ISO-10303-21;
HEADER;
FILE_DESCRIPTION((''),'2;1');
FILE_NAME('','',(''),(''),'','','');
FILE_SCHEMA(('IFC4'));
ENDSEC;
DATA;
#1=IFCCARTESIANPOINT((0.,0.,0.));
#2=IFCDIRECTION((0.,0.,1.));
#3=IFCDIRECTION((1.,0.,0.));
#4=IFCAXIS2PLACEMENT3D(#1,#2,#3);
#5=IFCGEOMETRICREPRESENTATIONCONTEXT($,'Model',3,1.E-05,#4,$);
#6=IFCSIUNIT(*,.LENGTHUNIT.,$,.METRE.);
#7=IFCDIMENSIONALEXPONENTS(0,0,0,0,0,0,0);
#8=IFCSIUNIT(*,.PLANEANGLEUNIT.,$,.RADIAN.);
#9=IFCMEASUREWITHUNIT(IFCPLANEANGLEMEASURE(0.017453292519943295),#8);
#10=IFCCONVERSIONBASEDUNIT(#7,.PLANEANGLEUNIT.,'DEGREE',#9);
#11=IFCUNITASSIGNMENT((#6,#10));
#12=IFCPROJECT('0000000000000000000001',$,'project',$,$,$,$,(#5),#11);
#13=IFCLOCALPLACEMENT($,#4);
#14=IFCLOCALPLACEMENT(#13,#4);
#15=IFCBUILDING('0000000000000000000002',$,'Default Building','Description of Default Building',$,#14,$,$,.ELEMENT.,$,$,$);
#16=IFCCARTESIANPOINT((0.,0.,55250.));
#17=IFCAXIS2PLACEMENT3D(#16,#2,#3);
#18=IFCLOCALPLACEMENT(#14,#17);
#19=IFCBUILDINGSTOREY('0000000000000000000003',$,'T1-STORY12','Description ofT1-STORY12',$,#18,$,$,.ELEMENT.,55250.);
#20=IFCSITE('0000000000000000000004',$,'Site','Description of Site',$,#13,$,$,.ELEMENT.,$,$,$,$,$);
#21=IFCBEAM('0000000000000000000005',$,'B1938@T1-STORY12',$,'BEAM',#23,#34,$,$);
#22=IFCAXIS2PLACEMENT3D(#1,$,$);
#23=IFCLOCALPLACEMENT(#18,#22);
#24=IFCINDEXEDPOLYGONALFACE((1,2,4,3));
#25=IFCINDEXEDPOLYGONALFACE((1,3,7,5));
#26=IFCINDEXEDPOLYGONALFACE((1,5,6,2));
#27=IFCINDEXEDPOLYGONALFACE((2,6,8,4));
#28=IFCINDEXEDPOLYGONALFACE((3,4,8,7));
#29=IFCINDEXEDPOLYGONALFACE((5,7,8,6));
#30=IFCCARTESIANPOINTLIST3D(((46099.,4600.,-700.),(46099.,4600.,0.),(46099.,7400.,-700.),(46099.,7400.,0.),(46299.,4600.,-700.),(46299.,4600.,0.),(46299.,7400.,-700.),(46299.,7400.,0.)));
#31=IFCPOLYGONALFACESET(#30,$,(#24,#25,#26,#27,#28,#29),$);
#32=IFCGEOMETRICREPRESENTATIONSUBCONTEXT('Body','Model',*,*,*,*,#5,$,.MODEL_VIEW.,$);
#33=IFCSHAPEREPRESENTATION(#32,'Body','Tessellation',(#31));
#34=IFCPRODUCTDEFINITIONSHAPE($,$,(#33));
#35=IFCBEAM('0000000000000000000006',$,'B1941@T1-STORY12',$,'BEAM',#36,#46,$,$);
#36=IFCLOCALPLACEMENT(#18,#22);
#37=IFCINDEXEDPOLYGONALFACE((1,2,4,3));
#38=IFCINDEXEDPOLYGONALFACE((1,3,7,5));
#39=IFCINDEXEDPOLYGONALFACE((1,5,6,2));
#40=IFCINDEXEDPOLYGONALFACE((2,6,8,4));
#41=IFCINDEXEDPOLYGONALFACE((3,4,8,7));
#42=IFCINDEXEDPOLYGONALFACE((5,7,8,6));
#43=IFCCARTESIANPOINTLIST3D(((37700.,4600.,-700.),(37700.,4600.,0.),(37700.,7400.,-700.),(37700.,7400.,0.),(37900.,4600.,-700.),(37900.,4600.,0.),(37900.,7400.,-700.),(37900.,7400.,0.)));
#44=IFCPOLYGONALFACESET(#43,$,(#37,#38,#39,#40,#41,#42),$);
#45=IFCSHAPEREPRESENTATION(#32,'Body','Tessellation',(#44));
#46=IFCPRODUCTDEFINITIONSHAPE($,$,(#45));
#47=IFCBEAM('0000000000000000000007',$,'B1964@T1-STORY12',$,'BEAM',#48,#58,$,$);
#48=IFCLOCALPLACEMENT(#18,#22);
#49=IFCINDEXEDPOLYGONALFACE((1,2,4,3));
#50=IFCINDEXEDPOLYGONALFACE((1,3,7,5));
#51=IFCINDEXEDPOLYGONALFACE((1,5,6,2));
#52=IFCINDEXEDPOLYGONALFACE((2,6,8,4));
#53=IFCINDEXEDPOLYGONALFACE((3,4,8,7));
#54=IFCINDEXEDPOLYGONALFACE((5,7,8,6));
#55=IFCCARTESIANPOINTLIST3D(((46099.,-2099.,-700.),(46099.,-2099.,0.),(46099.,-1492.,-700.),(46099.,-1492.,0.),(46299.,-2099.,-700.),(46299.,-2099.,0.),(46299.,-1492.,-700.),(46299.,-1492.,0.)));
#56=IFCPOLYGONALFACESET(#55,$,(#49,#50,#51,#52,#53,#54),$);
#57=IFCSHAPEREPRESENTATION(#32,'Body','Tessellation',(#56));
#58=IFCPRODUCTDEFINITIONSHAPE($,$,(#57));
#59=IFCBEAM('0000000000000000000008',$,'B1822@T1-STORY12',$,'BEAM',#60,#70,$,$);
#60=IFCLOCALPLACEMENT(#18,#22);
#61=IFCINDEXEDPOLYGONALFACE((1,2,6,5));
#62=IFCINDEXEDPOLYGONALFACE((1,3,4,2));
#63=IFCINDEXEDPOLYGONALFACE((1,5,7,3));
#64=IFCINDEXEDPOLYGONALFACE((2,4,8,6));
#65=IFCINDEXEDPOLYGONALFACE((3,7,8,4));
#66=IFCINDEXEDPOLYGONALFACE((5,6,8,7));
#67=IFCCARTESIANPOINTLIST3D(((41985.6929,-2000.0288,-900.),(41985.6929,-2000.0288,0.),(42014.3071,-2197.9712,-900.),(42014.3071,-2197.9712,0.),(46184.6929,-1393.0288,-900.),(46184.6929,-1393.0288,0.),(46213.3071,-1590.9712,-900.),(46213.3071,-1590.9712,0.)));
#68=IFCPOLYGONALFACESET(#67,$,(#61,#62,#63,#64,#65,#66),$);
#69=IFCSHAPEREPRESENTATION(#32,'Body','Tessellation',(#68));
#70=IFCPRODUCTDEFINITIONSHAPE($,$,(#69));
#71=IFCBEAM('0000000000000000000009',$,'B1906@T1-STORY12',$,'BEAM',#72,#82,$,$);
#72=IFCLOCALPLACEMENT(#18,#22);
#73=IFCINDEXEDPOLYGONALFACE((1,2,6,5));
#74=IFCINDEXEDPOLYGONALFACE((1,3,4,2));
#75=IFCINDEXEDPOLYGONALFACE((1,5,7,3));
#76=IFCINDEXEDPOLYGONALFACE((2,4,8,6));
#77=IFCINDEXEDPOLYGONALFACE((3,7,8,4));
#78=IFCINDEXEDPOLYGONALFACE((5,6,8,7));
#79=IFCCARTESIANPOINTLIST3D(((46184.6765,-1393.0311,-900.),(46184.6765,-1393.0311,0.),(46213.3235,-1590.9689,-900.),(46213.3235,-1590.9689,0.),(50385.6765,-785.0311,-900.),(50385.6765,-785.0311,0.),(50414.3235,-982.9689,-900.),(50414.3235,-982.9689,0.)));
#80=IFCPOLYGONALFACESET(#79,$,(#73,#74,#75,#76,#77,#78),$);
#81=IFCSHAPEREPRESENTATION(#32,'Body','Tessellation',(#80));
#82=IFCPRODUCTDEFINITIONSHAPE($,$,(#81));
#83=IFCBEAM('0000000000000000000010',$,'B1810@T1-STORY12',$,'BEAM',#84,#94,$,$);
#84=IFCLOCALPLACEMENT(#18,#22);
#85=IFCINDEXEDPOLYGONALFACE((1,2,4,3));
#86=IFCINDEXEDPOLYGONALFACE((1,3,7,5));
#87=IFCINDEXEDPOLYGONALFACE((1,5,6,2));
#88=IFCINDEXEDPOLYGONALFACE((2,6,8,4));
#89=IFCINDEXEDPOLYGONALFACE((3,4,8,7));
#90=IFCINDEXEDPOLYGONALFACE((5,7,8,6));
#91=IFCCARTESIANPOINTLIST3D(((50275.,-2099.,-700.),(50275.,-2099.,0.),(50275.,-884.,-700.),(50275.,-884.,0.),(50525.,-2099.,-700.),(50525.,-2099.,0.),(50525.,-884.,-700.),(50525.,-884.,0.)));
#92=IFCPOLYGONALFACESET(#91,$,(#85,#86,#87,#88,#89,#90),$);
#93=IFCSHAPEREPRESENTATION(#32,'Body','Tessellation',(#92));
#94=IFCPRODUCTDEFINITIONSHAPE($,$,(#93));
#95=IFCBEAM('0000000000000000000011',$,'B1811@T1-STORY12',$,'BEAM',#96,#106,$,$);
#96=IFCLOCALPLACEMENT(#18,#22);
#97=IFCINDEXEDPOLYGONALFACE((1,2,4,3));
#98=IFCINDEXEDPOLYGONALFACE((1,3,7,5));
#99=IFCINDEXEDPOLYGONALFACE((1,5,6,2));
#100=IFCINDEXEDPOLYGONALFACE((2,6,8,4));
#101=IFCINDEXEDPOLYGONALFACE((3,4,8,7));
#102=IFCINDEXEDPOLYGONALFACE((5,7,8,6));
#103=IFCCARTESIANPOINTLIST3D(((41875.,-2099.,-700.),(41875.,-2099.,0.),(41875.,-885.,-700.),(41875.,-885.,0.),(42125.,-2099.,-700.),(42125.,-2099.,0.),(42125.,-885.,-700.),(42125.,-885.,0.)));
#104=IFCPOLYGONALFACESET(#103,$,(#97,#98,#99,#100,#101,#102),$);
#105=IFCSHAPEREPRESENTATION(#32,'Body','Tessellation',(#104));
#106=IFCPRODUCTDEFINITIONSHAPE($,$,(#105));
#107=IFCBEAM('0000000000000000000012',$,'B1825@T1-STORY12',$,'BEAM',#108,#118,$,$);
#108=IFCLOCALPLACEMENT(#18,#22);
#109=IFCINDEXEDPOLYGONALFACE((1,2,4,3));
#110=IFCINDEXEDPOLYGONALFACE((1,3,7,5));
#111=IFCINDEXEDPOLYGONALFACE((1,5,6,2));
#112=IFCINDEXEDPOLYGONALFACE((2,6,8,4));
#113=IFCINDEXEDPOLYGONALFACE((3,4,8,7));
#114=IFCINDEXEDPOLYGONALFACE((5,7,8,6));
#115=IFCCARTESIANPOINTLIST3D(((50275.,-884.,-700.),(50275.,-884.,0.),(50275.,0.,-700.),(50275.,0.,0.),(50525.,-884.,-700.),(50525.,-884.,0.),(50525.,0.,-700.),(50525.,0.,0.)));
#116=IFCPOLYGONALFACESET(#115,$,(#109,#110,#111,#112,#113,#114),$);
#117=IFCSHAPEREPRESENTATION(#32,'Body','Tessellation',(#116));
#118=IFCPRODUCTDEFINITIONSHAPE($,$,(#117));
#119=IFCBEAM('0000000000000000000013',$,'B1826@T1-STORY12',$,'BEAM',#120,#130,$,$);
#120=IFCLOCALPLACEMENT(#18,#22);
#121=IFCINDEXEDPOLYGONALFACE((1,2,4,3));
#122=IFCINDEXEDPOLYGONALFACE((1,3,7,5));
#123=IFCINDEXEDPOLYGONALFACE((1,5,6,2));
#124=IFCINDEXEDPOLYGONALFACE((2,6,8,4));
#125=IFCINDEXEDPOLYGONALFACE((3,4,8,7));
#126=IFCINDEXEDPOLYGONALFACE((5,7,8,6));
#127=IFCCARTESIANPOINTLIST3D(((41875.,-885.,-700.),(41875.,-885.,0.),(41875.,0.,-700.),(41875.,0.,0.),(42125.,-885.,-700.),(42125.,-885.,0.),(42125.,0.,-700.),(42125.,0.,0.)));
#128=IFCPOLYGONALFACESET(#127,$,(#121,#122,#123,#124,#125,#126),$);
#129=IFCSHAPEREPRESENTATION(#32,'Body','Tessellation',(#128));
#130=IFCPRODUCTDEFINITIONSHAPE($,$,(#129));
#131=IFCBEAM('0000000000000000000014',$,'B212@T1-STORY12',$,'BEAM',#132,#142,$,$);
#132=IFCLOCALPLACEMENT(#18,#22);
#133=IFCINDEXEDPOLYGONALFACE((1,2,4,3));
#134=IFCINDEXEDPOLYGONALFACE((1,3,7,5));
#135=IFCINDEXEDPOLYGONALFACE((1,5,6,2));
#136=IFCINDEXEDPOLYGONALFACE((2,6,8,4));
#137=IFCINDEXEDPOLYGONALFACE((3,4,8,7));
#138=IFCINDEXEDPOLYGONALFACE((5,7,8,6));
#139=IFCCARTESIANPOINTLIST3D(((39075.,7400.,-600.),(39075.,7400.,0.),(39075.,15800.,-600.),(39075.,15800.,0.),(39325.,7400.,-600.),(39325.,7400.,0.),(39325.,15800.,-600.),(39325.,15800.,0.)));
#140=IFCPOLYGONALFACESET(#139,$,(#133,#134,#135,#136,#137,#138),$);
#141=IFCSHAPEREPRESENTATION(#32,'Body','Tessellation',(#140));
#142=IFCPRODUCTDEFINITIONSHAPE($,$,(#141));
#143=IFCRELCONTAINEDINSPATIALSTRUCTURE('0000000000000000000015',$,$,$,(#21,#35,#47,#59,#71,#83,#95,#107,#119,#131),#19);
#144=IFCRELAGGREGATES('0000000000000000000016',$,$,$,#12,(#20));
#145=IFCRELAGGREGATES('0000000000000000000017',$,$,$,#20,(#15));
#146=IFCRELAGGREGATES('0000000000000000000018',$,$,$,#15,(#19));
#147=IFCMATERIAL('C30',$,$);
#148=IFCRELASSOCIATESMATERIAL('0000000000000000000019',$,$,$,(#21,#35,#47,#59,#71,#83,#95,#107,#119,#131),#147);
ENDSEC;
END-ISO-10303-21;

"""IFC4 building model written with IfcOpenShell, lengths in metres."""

from ifc_helpers import new_model, entity, si_unit, converted_unit, frame, origin_with_axes, place, context, subcontext, project, spatial, rectangle, extrude, material, element, save


model = new_model("IFC4")

# Units and contexts
model_context = context("Model", 3, precision=1e-05, world=origin_with_axes())
body_context = subcontext(model_context, "Body", "Model", "MODEL_VIEW")
ifc_project = project(units=[si_unit("LENGTHUNIT", "METRE"), converted_unit("PLANEANGLEUNIT", "DEGREE", entity("IfcPlaneAngleMeasure", 0.017453292519943295), si_unit("PLANEANGLEUNIT", "RADIAN"), dimensions=[0, 0, 0, 0, 0, 0, 0])], contexts=[model_context])

# Site, building, storey
site_placement = place(None, origin_with_axes())
site = spatial("IfcSite", under=ifc_project, at=site_placement, Name="Site", Description="Description of Site", CompositionType="ELEMENT")
building_placement = place(site_placement, origin_with_axes())
building = spatial("IfcBuilding", under=site, at=building_placement, Name="Default Building", Description="Description of Default Building", CompositionType="ELEMENT")
storey_placement = place(building_placement, frame((0.0, 0.0, 55250.0), z_axis=(0.0, 0.0, 1.0), x_axis=(1.0, 0.0, 0.0)))
storey = spatial("IfcBuildingStorey", under=building, at=storey_placement, Name="T1-STORY12", Description="Description ofT1-STORY12", CompositionType="ELEMENT", Elevation=55250.0)

# Beams
ifc_material_1 = material(Name="C30")
for number, where, z_axis, x_axis, name in (
    (1, (46199.0, 4600.0, -350.0), (0.0, 1.0, 0.0), (-1.0, 0.0, 0.0), "B1938@T1-STORY12"),
    (2, (37800.0, 4600.0, -350.0), (0.0, 1.0, 0.0), (-1.0, 0.0, 0.0), "B1941@T1-STORY12"),
):
    element("IfcBeam", number, at=place(storey_placement, frame(where, z_axis=z_axis, x_axis=x_axis)), inside=storey, material=ifc_material_1, Name=name, ObjectType="BEAM", context=body_context, shape_type="SweptSolid", body=[
        extrude(rectangle(XDim=200.0, YDim=700.0), origin_with_axes(), (0.0, 0.0, 1.0), 2800.0),
    ])
beam_1_placement = place(storey_placement, frame((46199.0, -2099.0, -350.0), z_axis=(0.0, 1.0, 0.0), x_axis=(-1.0, 0.0, 0.0)))
element("IfcBeam", 3, at=beam_1_placement, inside=storey, material=ifc_material_1, Name="B1964@T1-STORY12", ObjectType="BEAM", context=body_context, shape_type="SweptSolid", body=[
    extrude(rectangle(XDim=200.0, YDim=700.0), origin_with_axes(), (0.0, 0.0, 1.0), 607.0),
])
beam_2_placement = place(storey_placement, frame((42000.0, -2099.0, -450.0), z_axis=(0.989712, 0.143071, 0.0), x_axis=(-0.143071, 0.989712, 0.0)))
element("IfcBeam", 4, at=beam_2_placement, inside=storey, material=ifc_material_1, Name="B1822@T1-STORY12", ObjectType="BEAM", context=body_context, shape_type="SweptSolid", body=[
    extrude(rectangle(XDim=200.0, YDim=900.0), origin_with_axes(), (0.0, 0.0, 1.0), 4242.6466),
])
beam_3_placement = place(storey_placement, frame((46199.0, -1492.0, -450.0), z_axis=(0.989689, 0.143235, 0.0), x_axis=(-0.143235, 0.989689, 0.0)))
element("IfcBeam", 5, at=beam_3_placement, inside=storey, material=ifc_material_1, Name="B1906@T1-STORY12", ObjectType="BEAM", context=body_context, shape_type="SweptSolid", body=[
    extrude(rectangle(XDim=200.0, YDim=900.0), origin_with_axes(), (0.0, 0.0, 1.0), 4244.7691),
])
beam_4_placement = place(storey_placement, frame((50400.0, -2099.0, -350.0), z_axis=(0.0, 1.0, 0.0), x_axis=(-1.0, 0.0, 0.0)))
element("IfcBeam", 6, at=beam_4_placement, inside=storey, material=ifc_material_1, Name="B1810@T1-STORY12", ObjectType="BEAM", context=body_context, shape_type="SweptSolid", body=[
    extrude(rectangle(XDim=250.0, YDim=700.0), origin_with_axes(), (0.0, 0.0, 1.0), 1215.0),
])
beam_5_placement = place(storey_placement, frame((42000.0, -2099.0, -350.0), z_axis=(0.0, 1.0, 0.0), x_axis=(-1.0, 0.0, 0.0)))
element("IfcBeam", 7, at=beam_5_placement, inside=storey, material=ifc_material_1, Name="B1811@T1-STORY12", ObjectType="BEAM", context=body_context, shape_type="SweptSolid", body=[
    extrude(rectangle(XDim=250.0, YDim=700.0), origin_with_axes(), (0.0, 0.0, 1.0), 1214.0),
])
beam_6_placement = place(storey_placement, frame((50400.0, -884.0, -350.0), z_axis=(0.0, 1.0, 0.0), x_axis=(-1.0, 0.0, 0.0)))
element("IfcBeam", 8, at=beam_6_placement, inside=storey, material=ifc_material_1, Name="B1825@T1-STORY12", ObjectType="BEAM", context=body_context, shape_type="SweptSolid", body=[
    extrude(rectangle(XDim=250.0, YDim=700.0), origin_with_axes(), (0.0, 0.0, 1.0), 884.0),
])
beam_7_placement = place(storey_placement, frame((42000.0, -885.0, -350.0), z_axis=(0.0, 1.0, 0.0), x_axis=(-1.0, 0.0, 0.0)))
element("IfcBeam", 9, at=beam_7_placement, inside=storey, material=ifc_material_1, Name="B1826@T1-STORY12", ObjectType="BEAM", context=body_context, shape_type="SweptSolid", body=[
    extrude(rectangle(XDim=250.0, YDim=700.0), origin_with_axes(), (0.0, 0.0, 1.0), 885.0),
])
beam_8_placement = place(storey_placement, frame((39200.0, 7400.0, -300.0), z_axis=(0.0, 1.0, 0.0), x_axis=(-1.0, 0.0, 0.0)))
element("IfcBeam", 10, at=beam_8_placement, inside=storey, material=ifc_material_1, Name="B212@T1-STORY12", ObjectType="BEAM", context=body_context, shape_type="SweptSolid", body=[
    extrude(rectangle(XDim=250.0, YDim=600.0), origin_with_axes(), (0.0, 0.0, 1.0), 8400.0),
])

save(model, "model.ifc")
